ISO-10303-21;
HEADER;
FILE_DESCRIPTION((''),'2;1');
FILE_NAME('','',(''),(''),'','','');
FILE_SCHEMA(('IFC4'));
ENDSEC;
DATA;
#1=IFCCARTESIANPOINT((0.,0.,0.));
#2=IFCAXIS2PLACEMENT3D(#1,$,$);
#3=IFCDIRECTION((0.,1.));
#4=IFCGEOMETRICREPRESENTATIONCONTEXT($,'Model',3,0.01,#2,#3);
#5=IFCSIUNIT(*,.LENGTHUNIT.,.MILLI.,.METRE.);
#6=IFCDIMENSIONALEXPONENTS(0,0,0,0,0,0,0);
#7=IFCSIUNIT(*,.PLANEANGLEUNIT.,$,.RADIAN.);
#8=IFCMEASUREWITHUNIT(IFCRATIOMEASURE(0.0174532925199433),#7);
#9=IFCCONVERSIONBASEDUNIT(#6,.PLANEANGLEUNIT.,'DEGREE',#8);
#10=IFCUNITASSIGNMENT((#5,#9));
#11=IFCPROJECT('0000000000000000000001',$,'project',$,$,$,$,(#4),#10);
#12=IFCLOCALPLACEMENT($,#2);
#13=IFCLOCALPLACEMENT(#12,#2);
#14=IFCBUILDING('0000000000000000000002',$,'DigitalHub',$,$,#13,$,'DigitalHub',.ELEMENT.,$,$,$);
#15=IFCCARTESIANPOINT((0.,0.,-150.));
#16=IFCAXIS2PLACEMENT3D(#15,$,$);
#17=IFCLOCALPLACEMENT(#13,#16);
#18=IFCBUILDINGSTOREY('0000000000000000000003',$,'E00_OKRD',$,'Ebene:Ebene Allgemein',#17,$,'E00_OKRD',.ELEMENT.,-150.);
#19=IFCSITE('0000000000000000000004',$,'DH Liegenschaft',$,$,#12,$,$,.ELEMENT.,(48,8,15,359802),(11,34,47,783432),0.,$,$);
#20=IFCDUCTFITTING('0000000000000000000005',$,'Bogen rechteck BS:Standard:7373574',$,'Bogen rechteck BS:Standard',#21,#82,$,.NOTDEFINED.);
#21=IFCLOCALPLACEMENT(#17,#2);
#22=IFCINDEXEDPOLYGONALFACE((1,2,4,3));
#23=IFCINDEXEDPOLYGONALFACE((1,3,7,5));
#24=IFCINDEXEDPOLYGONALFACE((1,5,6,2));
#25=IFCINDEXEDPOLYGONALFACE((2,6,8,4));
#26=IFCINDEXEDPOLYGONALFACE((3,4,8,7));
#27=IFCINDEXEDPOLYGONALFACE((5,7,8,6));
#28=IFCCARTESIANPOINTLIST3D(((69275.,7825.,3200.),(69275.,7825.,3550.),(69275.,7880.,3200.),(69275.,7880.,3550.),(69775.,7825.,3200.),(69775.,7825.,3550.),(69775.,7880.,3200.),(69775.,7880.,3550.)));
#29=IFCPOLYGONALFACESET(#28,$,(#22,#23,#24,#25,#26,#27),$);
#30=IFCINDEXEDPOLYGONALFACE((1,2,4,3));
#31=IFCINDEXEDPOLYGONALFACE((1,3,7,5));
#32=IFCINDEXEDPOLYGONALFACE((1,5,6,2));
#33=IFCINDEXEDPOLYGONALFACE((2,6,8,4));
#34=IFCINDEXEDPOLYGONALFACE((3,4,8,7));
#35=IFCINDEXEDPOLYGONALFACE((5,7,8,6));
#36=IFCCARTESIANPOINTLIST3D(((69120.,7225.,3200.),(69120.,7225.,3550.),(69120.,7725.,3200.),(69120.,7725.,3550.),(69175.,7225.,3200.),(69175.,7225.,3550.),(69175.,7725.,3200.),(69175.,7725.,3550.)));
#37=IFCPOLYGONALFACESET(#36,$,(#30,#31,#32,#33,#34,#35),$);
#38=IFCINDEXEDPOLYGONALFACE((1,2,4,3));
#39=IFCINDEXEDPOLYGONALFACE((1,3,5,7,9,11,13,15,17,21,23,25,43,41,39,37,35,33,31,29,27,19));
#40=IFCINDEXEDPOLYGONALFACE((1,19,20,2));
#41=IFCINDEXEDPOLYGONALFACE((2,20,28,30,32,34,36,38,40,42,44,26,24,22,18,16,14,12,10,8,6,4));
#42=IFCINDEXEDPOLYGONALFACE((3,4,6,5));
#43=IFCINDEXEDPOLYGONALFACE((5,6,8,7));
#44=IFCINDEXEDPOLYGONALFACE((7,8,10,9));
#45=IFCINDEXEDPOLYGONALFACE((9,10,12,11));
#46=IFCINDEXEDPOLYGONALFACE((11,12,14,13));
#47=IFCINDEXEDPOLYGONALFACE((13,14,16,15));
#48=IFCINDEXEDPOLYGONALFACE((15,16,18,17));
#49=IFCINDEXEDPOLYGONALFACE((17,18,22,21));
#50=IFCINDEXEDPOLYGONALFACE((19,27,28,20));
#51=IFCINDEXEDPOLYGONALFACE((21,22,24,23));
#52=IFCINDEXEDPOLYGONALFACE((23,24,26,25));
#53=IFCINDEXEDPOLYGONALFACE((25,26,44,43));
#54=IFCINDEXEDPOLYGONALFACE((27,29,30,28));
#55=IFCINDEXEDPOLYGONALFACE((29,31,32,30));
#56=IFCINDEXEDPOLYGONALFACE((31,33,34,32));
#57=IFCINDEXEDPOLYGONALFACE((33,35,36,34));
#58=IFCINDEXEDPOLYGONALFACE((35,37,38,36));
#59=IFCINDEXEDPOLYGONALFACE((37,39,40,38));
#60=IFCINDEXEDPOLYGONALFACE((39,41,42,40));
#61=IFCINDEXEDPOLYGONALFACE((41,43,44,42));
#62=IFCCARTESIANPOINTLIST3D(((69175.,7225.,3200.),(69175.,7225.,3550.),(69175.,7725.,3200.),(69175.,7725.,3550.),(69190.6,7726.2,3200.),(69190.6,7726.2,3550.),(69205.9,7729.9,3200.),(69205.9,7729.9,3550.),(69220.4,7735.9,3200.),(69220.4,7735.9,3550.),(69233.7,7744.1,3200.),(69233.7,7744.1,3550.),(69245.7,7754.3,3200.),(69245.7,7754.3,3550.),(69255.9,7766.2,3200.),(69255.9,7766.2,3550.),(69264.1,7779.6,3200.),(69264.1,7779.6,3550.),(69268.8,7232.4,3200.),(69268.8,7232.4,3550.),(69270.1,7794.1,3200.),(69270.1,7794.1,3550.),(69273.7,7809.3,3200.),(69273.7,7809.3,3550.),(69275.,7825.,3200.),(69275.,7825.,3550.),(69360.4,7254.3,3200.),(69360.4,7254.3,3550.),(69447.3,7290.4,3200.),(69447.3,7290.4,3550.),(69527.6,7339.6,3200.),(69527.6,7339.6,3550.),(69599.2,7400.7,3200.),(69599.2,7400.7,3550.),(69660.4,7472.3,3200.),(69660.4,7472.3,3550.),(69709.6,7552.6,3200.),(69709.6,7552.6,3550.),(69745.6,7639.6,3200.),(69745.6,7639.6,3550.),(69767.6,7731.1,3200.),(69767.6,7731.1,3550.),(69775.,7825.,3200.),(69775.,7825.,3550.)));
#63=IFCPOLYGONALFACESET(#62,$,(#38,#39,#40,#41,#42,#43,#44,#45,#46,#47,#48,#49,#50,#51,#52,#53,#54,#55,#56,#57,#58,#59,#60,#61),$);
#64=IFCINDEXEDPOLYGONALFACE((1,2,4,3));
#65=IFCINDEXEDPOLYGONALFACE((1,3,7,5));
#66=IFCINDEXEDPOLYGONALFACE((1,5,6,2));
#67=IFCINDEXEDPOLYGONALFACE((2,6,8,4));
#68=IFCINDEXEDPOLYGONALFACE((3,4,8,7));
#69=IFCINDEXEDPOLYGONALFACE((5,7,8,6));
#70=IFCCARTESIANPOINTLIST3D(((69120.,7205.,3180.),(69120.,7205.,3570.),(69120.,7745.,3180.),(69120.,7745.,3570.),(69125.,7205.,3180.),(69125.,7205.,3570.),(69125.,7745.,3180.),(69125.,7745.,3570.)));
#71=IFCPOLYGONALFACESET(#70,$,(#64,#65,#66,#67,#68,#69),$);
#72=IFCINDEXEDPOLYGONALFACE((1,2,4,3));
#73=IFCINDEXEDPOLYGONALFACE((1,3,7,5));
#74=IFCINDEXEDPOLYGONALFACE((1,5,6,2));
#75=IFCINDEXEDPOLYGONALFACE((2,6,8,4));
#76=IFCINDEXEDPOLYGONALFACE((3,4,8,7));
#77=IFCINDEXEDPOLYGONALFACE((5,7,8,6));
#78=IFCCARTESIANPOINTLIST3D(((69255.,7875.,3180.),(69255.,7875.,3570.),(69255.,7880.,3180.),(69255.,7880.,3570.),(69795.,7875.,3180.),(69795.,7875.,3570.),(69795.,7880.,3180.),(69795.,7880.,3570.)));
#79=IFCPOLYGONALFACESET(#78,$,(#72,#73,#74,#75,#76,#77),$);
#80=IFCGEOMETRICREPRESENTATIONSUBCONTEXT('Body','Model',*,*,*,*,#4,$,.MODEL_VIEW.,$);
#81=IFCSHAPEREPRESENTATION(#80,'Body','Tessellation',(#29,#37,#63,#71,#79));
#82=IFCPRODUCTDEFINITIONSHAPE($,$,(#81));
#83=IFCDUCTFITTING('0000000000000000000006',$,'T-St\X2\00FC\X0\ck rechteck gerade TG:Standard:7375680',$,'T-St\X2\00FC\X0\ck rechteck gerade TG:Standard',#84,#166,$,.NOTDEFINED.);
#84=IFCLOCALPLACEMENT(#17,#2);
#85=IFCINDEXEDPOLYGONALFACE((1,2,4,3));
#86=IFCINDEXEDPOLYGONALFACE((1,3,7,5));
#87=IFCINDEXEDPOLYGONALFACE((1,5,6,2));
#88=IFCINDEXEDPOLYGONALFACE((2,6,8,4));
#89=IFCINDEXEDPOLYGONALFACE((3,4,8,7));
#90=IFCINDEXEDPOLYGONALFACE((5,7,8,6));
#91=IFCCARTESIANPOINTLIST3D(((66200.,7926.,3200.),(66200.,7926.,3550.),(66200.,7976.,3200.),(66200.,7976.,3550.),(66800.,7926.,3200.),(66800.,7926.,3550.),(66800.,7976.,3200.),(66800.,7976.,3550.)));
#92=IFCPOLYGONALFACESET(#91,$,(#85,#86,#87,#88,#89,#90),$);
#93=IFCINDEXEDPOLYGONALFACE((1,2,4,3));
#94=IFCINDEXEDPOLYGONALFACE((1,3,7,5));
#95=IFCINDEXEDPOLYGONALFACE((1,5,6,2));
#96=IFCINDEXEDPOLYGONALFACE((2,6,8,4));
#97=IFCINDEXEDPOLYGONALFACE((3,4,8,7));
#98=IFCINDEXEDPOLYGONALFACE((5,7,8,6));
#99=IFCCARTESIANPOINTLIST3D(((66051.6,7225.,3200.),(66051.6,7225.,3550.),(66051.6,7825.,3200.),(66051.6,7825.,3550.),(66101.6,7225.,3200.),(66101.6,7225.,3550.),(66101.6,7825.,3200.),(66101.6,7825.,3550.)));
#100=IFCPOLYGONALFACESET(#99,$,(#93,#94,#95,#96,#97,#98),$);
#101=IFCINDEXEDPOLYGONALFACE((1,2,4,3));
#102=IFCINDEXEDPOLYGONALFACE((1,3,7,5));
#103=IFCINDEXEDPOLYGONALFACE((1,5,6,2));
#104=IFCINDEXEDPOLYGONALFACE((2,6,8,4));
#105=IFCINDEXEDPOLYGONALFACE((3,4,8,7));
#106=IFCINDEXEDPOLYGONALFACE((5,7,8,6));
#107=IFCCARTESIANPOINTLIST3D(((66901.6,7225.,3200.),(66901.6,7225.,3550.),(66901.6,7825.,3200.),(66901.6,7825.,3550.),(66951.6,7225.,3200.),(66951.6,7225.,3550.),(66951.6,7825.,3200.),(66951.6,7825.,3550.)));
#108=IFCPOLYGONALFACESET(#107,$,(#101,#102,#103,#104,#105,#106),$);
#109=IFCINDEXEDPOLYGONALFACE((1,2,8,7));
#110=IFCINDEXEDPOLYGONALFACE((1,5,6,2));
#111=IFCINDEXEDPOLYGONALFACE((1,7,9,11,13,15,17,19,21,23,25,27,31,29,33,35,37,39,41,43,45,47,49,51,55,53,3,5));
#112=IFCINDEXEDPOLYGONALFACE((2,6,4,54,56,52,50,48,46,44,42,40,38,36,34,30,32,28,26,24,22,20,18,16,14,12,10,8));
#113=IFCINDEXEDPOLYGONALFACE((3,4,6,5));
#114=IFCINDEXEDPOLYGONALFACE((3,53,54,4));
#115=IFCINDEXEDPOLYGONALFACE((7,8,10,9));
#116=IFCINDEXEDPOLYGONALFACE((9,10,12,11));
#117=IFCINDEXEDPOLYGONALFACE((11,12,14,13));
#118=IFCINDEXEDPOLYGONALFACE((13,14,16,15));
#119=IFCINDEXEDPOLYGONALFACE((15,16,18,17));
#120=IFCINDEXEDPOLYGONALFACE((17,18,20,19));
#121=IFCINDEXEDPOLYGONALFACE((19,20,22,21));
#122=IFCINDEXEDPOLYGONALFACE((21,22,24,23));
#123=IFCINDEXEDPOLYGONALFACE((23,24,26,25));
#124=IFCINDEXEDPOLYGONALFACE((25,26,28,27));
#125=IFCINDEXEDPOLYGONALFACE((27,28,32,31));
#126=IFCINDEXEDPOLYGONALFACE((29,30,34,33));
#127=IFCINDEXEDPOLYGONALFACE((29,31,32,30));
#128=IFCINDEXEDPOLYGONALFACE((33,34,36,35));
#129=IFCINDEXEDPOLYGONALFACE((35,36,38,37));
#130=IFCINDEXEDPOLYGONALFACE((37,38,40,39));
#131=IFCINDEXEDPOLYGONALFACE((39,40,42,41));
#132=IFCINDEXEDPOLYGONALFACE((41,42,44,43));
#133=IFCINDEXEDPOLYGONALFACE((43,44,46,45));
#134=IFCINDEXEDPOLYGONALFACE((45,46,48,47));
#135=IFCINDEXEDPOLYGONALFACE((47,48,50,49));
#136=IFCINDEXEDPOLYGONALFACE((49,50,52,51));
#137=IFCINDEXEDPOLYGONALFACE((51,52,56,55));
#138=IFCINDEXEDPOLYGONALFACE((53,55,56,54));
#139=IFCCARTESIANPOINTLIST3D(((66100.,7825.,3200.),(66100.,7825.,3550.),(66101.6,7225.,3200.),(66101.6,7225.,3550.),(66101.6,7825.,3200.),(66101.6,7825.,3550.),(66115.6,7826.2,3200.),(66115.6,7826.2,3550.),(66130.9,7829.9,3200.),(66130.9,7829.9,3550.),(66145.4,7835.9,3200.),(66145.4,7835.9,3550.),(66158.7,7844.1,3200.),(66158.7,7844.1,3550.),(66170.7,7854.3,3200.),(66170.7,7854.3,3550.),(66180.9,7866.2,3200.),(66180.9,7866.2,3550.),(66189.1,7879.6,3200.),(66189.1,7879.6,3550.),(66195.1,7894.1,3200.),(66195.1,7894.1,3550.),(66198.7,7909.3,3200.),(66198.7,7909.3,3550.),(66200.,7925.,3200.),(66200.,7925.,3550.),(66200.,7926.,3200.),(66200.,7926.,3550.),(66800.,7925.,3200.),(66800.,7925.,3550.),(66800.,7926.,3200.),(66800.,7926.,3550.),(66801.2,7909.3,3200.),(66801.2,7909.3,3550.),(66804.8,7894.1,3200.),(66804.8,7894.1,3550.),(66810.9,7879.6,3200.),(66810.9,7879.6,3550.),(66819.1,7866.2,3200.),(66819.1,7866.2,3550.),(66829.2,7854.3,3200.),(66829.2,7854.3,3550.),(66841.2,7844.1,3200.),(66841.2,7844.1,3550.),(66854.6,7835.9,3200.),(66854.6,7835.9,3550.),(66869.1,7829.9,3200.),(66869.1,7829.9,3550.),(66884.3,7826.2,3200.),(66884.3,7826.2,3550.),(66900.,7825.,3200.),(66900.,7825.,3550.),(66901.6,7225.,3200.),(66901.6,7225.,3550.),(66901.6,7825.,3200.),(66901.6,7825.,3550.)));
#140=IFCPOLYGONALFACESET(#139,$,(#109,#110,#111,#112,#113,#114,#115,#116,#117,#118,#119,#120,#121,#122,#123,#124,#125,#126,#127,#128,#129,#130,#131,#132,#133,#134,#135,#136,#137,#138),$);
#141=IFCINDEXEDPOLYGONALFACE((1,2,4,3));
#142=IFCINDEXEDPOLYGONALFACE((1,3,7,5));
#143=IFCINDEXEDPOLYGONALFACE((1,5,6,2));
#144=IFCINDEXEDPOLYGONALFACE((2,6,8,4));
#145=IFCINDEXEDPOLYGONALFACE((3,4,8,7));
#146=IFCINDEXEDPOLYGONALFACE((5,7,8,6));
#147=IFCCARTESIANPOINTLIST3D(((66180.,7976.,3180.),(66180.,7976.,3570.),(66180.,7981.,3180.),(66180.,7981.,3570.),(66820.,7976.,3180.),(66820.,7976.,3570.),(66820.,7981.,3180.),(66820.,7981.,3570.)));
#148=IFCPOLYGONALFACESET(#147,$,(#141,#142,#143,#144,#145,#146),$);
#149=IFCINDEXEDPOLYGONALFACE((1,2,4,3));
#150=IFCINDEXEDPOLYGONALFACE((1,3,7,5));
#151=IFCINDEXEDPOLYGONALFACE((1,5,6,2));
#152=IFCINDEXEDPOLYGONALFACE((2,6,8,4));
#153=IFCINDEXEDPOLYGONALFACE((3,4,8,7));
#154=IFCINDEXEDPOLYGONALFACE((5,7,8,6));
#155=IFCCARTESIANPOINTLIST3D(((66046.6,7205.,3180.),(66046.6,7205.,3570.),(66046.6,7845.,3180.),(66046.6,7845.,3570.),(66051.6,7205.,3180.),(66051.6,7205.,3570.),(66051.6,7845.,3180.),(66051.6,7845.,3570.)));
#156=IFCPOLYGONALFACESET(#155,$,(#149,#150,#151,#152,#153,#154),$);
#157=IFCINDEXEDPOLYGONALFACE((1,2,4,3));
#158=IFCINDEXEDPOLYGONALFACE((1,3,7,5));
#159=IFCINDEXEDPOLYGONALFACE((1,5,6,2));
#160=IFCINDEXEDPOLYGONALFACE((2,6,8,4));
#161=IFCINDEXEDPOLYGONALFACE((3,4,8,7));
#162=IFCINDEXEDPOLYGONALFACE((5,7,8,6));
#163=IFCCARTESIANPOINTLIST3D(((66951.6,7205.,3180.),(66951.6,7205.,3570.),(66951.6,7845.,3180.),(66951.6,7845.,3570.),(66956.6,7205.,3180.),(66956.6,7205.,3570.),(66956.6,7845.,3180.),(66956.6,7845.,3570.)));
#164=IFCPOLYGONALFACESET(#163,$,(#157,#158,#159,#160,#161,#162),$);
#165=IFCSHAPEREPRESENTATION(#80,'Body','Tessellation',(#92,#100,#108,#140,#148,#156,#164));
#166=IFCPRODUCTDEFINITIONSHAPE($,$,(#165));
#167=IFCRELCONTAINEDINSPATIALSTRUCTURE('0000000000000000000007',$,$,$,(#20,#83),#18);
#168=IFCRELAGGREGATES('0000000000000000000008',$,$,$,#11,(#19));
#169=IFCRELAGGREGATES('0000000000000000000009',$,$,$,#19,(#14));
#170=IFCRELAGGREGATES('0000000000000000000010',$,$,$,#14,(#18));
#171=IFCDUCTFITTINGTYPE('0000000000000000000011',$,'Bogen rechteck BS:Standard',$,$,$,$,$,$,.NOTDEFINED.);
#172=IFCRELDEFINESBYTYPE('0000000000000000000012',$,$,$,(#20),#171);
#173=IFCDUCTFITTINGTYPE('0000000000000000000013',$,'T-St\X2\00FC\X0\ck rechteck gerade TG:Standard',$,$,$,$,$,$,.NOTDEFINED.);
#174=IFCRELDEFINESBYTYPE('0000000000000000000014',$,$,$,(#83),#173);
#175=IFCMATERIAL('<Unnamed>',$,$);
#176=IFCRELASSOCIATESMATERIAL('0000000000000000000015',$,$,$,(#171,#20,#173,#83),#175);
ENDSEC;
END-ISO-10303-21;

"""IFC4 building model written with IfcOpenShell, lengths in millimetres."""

from ifc_helpers import new_model, entity, si_unit, converted_unit, direction, frame, origin, place, context, subcontext, project, spatial, indexed_curve, outline, extrude, source, transform, mapped, material, type_object, type_shapes, element, save


model = new_model("IFC4")

# Units and contexts
model_context = context("Model", 3, precision=0.01, world=origin(), true_north=direction((0.0, 1.0)))
body_context = subcontext(model_context, "Body", "Model", "MODEL_VIEW")
ifc_project = project(units=[si_unit("LENGTHUNIT", "METRE", prefix="MILLI"), converted_unit("PLANEANGLEUNIT", "DEGREE", entity("IfcRatioMeasure", 0.0174532925199433), si_unit("PLANEANGLEUNIT", "RADIAN"), dimensions=[0, 0, 0, 0, 0, 0, 0])], contexts=[model_context])

# Site, building, storey
site_placement = place(None, origin())
site = spatial("IfcSite", under=ifc_project, at=site_placement, Name="DH Liegenschaft", CompositionType="ELEMENT", RefLatitude=(48, 8, 15, 359802), RefLongitude=(11, 34, 47, 783432), RefElevation=0.0)
building_placement = place(site_placement, origin())
building = spatial("IfcBuilding", under=site, at=building_placement, Name="DigitalHub", LongName="DigitalHub", CompositionType="ELEMENT")
storey_placement = place(building_placement, frame((0.0, 0.0, -150.0)))
storey = spatial("IfcBuildingStorey", under=building, at=storey_placement, Name="E00_OKRD", ObjectType="Ebene:Ebene Allgemein", LongName="E00_OKRD", CompositionType="ELEMENT", Elevation=-150.0)

# Shared definitions
ifc_material_1 = material(Name="<Unnamed>")

# Duct fittings
duct_fitting_type_1 = type_object("IfcDuctFittingType", Name="Bogen rechteck BS:Standard", PredefinedType="NOTDEFINED", material=ifc_material_1)
shared_shape_1 = source(origin(), body_context, "Body", "SweptSolid", [
    extrude(outline(indexed_curve([(-27.5, -250.0), (27.5, -250.0), (27.5, 250.0), (-27.5, 250.0), (-27.5, -250.0)], self_intersect=False)), frame((0.0, 377.5, -175.0), z_axis=(0.0, 0.0, 1.0), x_axis=(0.0, 1.0, 0.0)), (0.0, 0.0, 1.0), 350.0),
    extrude(outline(indexed_curve([(-250.0, -27.5), (250.0, -27.5), (250.0, 27.5), (-250.0, 27.5), (-250.0, -27.5)], self_intersect=False)), frame((-377.5, 0.0, -175.0), z_axis=(0.0, 0.0, 1.0), x_axis=(0.0, -1.0, 0.0)), (0.0, 0.0, 1.0), 350.0),
    extrude(outline(indexed_curve([(-425.0, -175.0), (75.0, -175.0), (76.2, -159.4), (79.9, -144.1), (85.9, -129.6), (94.1, -116.2), (104.3, -104.3), (116.2, -94.1), (129.6, -85.9), (144.1, -79.9), (159.4, -76.2), (175.0, -75.0), (175.0, 425.0), (81.1, 417.6), (-10.4, 395.6), (-97.4, 359.6), (-177.7, 310.4), (-249.3, 249.3), (-310.4, 177.7), (-359.6, 97.4), (-395.6, 10.4), (-417.6, -81.1), (-425.0, -175.0)], self_intersect=False)), frame((-175.0, 175.0, -175.0), z_axis=(0.0, 0.0, 1.0), x_axis=(-1.0, 0.0, 0.0)), (0.0, 0.0, 1.0), 350.0),
    extrude(outline(indexed_curve([(-2.5, -270.0), (2.5, -270.0), (2.5, 270.0), (-2.5, 270.0), (-2.5, -270.0)], self_intersect=False)), frame((-402.5, 0.0, -195.0)), (0.0, 0.0, 1.0), 390.0),
    extrude(outline(indexed_curve([(-2.5, -270.0), (2.5, -270.0), (2.5, 270.0), (-2.5, 270.0), (-2.5, -270.0)], self_intersect=False)), frame((0.0, 402.5, -195.0), z_axis=(0.0, 0.0, 1.0), x_axis=(0.0, 1.0, 0.0)), (0.0, 0.0, 1.0), 390.0),
])
type_shapes(duct_fitting_type_1, [shared_shape_1])
duct_fitting_1_placement = place(storey_placement, frame((69525.0, 7475.0, 3375.0)))
element("IfcDuctFitting", 1, at=duct_fitting_1_placement, inside=storey, type_object=duct_fitting_type_1, material=ifc_material_1, Name="Bogen rechteck BS:Standard:7373574", ObjectType="Bogen rechteck BS:Standard", PredefinedType="NOTDEFINED", context=body_context, shape_type="MappedRepresentation", body=[
    mapped(shared_shape_1, transform((0.0, 0.0, 0.0), scale=1.0)),
])
duct_fitting_type_2 = type_object("IfcDuctFittingType", Name="T-Stück rechteck gerade TG:Standard", PredefinedType="NOTDEFINED", material=ifc_material_1)
shared_shape_2 = source(origin(), body_context, "Body", "SweptSolid", [
    extrude(outline(indexed_curve([(-25.0, -300.0), (25.0, -300.0), (25.0, 300.0), (-25.0, 300.0), (-25.0, -300.0)], self_intersect=False)), frame((0.0, -426.0, -175.0), z_axis=(0.0, 0.0, 1.0), x_axis=(0.0, -1.0, 0.0)), (0.0, 0.0, 1.0), 350.0),
    extrude(outline(indexed_curve([(-25.0, -300.0), (25.0, -300.0), (25.0, 300.0), (-25.0, 300.0), (-25.0, -300.0)], self_intersect=False)), frame((423.4, 0.0, -175.0), z_axis=(0.0, 0.0, 1.0), x_axis=(-1.0, 0.0, 0.0)), (0.0, 0.0, 1.0), 350.0),
    extrude(outline(indexed_curve([(-25.0, -300.0), (25.0, -300.0), (25.0, 300.0), (-25.0, 300.0), (-25.0, -300.0)], self_intersect=False)), frame((-426.6, 0.0, -175.0)), (0.0, 0.0, 1.0), 350.0),
    extrude(outline(indexed_curve([(-400.6, -79.8), (-385.0, -81.0), (-369.7, -84.7), (-355.2, -90.7), (-341.9, -98.9), (-329.9, -109.1), (-319.7, -121.0), (-311.5, -134.4), (-305.5, -148.9), (-301.9, -164.2), (-300.6, -179.8), (-300.6, -180.8), (299.4, -180.8), (299.4, -179.8), (300.6, -164.2), (304.3, -148.9), (310.3, -134.4), (318.5, -121.0), (328.6, -109.1), (340.6, -98.9), (354.0, -90.7), (368.5, -84.7), (383.7, -81.0), (399.4, -79.8), (401.0, -79.8), (401.0, 520.2), (-399.0, 520.2), (-399.0, -79.8), (-400.6, -79.8)], self_intersect=False)), frame((-0.6, -220.2, -175.0), z_axis=(0.0, 0.0, -1.0), x_axis=(-1.0, 0.0, 0.0)), (0.0, 0.0, -1.0), 350.0),
    extrude(outline(indexed_curve([(-2.5, -320.0), (2.5, -320.0), (2.5, 320.0), (-2.5, 320.0), (-2.5, -320.0)], self_intersect=False)), frame((0.0, -453.5, -195.0), z_axis=(0.0, 0.0, 1.0), x_axis=(0.0, 1.0, 0.0)), (0.0, 0.0, 1.0), 390.0),
    extrude(outline(indexed_curve([(-2.5, -320.0), (2.5, -320.0), (2.5, 320.0), (-2.5, 320.0), (-2.5, -320.0)], self_intersect=False)), frame((450.9, 0.0, -195.0), z_axis=(0.0, 0.0, 1.0), x_axis=(-1.0, 0.0, 0.0)), (0.0, 0.0, 1.0), 390.0),
    extrude(outline(indexed_curve([(-2.5, -320.0), (2.5, -320.0), (2.5, 320.0), (-2.5, 320.0), (-2.5, -320.0)], self_intersect=False)), frame((-454.1, 0.0, -195.0), z_axis=(0.0, 0.0, 1.0), x_axis=(-1.0, 0.0, 0.0)), (0.0, 0.0, 1.0), 390.0),
])
type_shapes(duct_fitting_type_2, [shared_shape_2])
duct_fitting_2_placement = place(storey_placement, frame((66500.0, 7525.0, 3375.0), z_axis=(0.0, 0.0, 1.0), x_axis=(-1.0, 0.0, 0.0)))
element("IfcDuctFitting", 2, at=duct_fitting_2_placement, inside=storey, type_object=duct_fitting_type_2, material=ifc_material_1, Name="T-Stück rechteck gerade TG:Standard:7375680", ObjectType="T-Stück rechteck gerade TG:Standard", PredefinedType="NOTDEFINED", context=body_context, shape_type="MappedRepresentation", body=[
    mapped(shared_shape_2, transform((0.0, 0.0, 0.0), scale=1.0)),
])

save(model, "model.ifc")
